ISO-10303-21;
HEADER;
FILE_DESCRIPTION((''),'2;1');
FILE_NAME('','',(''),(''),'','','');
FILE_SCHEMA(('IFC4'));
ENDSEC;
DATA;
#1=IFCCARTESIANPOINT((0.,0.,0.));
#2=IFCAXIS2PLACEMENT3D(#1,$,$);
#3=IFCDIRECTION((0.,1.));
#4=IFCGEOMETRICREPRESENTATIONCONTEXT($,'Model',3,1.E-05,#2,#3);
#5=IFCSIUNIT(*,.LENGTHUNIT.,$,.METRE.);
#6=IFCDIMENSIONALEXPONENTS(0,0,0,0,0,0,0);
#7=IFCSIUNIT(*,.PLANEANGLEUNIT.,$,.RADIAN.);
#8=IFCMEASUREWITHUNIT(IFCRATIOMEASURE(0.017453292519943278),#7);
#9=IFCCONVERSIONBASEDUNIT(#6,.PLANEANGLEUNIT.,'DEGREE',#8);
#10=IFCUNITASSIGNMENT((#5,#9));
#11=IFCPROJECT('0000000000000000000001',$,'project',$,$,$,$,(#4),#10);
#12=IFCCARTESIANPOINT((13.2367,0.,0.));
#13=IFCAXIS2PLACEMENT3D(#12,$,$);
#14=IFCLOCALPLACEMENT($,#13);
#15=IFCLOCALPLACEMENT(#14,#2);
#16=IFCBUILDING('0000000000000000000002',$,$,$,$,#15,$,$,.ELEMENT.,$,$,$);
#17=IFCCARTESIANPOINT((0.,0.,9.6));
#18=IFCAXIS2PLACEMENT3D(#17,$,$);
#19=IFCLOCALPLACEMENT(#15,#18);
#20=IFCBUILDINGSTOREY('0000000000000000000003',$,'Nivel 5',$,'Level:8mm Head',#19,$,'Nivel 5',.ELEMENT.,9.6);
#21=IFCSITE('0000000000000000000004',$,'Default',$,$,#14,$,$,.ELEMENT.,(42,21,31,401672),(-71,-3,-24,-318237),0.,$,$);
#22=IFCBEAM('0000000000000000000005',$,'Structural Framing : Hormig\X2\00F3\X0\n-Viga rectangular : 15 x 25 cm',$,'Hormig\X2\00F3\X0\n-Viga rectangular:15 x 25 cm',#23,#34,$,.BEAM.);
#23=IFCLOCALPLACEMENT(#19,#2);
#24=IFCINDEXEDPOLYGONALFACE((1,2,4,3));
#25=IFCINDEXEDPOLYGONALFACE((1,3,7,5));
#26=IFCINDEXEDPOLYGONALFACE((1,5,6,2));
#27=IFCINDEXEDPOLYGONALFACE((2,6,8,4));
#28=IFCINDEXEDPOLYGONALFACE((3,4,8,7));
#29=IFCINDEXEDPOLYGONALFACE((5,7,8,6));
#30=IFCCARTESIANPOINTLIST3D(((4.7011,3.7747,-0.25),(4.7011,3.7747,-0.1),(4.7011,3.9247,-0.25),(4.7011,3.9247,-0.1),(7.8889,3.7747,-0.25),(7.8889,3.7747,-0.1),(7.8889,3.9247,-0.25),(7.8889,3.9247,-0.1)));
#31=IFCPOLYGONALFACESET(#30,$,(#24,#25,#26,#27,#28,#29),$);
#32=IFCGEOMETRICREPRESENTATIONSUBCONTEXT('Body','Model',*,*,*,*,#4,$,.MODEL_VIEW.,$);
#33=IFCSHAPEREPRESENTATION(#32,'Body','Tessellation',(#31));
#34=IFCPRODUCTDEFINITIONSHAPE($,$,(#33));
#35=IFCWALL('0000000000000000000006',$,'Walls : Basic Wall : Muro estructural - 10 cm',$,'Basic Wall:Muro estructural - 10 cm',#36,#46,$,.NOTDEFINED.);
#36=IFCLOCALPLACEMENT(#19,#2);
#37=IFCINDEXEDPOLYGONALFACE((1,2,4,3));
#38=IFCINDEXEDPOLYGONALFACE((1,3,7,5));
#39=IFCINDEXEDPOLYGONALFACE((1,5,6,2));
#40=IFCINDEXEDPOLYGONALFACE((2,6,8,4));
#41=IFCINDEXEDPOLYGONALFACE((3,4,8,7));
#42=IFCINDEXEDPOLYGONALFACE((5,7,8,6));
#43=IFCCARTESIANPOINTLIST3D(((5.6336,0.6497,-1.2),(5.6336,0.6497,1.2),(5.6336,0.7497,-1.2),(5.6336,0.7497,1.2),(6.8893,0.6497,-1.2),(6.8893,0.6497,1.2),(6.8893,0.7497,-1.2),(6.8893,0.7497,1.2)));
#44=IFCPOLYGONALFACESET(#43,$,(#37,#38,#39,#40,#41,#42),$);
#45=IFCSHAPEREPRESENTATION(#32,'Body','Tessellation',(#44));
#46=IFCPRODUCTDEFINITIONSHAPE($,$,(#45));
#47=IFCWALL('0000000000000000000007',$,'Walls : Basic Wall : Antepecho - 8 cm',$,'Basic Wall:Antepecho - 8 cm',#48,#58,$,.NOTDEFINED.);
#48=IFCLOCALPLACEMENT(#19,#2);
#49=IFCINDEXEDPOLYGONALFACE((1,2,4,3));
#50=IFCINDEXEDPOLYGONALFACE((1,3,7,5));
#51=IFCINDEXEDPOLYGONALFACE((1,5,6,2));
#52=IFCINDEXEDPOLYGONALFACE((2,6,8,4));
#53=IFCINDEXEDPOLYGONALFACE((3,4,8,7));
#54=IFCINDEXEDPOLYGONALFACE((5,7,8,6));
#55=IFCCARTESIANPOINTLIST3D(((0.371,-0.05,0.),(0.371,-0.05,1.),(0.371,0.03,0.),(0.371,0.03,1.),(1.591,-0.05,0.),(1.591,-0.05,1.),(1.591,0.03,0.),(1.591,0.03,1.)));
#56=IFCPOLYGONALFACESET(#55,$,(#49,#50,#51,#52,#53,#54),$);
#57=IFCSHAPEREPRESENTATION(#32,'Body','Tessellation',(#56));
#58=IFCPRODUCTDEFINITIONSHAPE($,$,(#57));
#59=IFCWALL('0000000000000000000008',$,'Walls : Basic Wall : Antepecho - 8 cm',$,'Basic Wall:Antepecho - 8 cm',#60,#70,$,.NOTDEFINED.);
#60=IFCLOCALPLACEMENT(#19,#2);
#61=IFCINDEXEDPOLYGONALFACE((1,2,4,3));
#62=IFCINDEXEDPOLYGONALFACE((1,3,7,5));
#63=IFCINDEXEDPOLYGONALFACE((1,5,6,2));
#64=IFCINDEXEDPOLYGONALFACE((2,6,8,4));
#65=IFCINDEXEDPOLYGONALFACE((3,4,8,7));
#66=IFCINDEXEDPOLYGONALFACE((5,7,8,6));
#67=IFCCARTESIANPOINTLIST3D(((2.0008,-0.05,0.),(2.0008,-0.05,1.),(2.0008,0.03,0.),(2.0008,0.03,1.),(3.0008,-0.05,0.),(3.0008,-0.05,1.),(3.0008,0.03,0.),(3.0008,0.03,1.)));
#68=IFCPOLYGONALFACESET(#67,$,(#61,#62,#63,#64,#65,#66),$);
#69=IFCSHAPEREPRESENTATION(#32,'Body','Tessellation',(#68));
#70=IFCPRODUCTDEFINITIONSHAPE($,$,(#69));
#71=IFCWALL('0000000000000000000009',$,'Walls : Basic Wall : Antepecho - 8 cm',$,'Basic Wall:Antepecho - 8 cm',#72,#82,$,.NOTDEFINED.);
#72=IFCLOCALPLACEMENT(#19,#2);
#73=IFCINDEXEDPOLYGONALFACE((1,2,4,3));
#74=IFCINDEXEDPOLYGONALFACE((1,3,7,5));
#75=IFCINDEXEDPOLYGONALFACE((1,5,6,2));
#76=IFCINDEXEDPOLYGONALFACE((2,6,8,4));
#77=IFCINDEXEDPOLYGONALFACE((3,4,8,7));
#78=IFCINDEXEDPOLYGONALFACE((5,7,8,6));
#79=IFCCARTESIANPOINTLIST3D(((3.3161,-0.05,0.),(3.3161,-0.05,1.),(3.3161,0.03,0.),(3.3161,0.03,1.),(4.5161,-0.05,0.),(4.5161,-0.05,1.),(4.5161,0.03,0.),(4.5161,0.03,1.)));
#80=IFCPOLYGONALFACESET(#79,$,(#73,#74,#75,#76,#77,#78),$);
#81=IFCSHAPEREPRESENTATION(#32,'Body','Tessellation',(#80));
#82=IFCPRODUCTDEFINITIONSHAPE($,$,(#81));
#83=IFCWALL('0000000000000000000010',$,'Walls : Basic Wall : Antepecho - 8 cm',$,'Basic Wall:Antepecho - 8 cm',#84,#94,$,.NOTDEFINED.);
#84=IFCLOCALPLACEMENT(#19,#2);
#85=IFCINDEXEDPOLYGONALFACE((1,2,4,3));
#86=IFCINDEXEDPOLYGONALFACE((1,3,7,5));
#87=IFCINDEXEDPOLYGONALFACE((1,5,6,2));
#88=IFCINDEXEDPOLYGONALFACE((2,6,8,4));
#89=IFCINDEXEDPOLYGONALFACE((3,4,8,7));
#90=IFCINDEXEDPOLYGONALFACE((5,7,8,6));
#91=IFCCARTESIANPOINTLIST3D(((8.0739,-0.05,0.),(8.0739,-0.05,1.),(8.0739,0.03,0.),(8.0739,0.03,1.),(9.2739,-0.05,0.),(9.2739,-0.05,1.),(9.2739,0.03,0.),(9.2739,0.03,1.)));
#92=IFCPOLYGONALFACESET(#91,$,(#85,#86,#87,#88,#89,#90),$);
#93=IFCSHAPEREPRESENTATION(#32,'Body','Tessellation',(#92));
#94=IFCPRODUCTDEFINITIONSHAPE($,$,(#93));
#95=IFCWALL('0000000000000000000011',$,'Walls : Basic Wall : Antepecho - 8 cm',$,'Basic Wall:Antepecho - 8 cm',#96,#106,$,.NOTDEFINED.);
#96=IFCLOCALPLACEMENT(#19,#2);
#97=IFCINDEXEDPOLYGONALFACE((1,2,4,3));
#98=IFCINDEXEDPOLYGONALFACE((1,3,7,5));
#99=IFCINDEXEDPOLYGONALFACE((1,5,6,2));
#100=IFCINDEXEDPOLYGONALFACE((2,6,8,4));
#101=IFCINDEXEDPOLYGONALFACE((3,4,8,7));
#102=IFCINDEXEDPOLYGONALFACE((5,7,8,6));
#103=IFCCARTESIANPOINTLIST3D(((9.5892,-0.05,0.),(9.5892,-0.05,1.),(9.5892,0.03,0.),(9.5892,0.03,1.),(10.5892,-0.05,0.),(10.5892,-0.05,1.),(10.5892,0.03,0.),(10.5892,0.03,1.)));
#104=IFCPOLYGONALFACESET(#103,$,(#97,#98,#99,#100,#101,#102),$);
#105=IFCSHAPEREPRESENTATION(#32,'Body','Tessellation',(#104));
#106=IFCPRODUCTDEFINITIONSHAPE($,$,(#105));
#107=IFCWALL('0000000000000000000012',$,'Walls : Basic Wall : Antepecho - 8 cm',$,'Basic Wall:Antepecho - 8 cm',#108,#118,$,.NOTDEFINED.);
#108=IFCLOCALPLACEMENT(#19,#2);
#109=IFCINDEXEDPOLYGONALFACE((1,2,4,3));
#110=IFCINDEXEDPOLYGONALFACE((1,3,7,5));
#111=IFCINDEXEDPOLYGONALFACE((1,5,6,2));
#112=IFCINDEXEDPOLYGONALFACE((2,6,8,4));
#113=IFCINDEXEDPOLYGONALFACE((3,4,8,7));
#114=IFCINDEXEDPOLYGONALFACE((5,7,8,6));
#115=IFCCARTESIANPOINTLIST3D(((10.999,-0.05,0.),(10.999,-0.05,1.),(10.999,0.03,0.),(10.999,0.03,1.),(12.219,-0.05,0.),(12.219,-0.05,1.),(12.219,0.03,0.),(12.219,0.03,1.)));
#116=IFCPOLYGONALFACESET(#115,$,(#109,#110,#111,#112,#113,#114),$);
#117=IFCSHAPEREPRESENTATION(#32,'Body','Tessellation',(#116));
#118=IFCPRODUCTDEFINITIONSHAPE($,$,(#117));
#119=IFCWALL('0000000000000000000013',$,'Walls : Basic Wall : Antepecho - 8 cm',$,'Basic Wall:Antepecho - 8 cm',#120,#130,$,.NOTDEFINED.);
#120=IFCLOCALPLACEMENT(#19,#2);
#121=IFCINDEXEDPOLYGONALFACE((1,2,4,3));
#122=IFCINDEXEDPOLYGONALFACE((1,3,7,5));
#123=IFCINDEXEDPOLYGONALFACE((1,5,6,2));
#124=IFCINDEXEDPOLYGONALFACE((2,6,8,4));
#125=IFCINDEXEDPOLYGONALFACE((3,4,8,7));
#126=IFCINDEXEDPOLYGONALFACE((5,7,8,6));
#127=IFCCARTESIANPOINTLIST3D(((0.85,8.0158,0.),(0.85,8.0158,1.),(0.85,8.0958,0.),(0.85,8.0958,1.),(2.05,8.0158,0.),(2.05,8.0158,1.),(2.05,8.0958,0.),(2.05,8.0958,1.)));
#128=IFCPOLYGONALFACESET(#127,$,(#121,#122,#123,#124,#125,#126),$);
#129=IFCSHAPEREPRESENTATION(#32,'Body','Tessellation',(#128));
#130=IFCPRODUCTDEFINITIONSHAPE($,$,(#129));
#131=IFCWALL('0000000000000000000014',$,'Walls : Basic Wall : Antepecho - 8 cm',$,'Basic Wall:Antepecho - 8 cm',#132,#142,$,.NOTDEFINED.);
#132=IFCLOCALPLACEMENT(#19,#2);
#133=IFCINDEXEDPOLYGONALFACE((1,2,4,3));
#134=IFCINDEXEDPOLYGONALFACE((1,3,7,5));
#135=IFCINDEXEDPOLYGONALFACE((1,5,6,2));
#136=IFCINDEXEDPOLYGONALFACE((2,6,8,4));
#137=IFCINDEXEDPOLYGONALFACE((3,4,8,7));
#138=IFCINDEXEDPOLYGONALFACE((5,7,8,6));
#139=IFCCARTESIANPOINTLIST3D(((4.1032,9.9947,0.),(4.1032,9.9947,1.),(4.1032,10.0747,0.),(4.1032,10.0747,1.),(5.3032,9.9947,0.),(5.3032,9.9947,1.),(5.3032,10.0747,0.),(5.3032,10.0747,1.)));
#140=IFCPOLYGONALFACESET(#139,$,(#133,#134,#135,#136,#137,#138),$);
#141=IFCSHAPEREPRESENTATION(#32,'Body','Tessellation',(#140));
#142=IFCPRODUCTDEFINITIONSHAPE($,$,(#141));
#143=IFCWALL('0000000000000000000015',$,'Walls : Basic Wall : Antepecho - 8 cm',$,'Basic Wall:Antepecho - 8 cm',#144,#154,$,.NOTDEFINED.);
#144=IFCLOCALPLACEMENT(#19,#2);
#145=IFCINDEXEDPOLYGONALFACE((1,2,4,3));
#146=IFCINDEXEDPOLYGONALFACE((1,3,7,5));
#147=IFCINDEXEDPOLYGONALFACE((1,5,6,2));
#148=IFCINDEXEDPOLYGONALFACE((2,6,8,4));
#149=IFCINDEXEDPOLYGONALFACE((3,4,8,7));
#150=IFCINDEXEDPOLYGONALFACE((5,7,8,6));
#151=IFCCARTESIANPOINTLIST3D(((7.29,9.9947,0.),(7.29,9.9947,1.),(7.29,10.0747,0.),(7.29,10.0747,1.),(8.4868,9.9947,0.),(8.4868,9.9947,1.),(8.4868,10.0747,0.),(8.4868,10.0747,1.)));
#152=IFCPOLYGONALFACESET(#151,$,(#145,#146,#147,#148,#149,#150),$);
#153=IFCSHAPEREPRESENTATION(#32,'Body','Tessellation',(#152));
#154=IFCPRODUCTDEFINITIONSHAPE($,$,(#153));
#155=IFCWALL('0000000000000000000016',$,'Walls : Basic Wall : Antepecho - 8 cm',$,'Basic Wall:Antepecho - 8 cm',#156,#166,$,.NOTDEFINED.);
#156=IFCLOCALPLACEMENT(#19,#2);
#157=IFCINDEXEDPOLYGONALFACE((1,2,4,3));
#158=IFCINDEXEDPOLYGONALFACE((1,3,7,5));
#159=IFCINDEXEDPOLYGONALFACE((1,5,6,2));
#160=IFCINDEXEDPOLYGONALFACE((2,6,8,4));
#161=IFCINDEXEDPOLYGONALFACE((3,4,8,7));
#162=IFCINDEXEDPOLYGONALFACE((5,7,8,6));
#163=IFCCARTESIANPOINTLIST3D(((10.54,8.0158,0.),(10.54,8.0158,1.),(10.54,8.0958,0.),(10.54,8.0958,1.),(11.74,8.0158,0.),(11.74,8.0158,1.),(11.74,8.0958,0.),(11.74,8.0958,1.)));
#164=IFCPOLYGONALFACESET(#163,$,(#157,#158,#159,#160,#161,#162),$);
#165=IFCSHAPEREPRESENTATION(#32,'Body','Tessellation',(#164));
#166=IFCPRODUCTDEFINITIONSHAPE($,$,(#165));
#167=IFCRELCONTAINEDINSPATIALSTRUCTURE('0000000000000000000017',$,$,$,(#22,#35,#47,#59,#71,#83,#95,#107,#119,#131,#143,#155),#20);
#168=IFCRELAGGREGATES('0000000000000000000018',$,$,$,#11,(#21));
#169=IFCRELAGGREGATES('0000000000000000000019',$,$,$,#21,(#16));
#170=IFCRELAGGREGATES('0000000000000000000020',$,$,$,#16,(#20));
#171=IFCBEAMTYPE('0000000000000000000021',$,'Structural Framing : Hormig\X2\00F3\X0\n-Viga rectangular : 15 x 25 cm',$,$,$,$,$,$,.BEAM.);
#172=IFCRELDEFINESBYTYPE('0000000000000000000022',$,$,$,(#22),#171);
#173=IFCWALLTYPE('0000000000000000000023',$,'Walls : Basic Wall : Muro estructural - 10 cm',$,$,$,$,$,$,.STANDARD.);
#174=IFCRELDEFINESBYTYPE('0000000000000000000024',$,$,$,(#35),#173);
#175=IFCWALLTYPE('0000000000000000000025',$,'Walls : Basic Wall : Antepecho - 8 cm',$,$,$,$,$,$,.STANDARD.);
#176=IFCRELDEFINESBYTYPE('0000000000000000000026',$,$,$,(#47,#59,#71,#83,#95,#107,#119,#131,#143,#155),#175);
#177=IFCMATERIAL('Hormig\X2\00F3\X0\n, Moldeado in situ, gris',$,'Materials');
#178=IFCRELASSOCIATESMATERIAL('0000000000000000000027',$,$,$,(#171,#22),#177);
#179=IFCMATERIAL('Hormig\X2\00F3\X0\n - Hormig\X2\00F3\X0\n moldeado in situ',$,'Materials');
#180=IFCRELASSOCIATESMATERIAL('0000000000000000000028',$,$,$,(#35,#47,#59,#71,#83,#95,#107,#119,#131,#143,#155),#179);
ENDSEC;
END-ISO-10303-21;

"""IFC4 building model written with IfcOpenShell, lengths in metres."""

from ifc_helpers import new_model, entity, si_unit, converted_unit, direction, frame, origin, place, context, subcontext, project, spatial, indexed_curve, outline, extrude, source, transform, mapped, material, type_object, type_shapes, element, save


model = new_model("IFC4")

# Units and contexts
model_context = context("Model", 3, precision=1e-05, world=origin(), true_north=direction((0.0, 1.0)))
body_context = subcontext(model_context, "Body", "Model", "MODEL_VIEW")
ifc_project = project(units=[si_unit("LENGTHUNIT", "METRE"), converted_unit("PLANEANGLEUNIT", "DEGREE", entity("IfcRatioMeasure", 0.017453292519943278), si_unit("PLANEANGLEUNIT", "RADIAN"), dimensions=[0, 0, 0, 0, 0, 0, 0])], contexts=[model_context])

# Site, building, storey
site_placement = place(None, frame((13.2367, 0.0, 0.0)))
site = spatial("IfcSite", under=ifc_project, at=site_placement, Name="Default", CompositionType="ELEMENT", RefLatitude=(42, 21, 31, 401672), RefLongitude=(-71, -3, -24, -318237), RefElevation=0.0)
building_placement = place(site_placement, origin())
building = spatial("IfcBuilding", under=site, at=building_placement, CompositionType="ELEMENT")
storey_placement = place(building_placement, frame((0.0, 0.0, 9.6)))
storey = spatial("IfcBuildingStorey", under=building, at=storey_placement, Name="Nivel 5", ObjectType="Level:8mm Head", LongName="Nivel 5", CompositionType="ELEMENT", Elevation=9.6)

# Beam
ifc_material_1 = material(Name="Hormigón, Moldeado in situ, gris", Category="Materials")
beam_type_1 = type_object("IfcBeamType", Name="Structural Framing : Hormigón-Viga rectangular : 15 x 25 cm", PredefinedType="BEAM", material=ifc_material_1)
shared_shape_1 = source(origin(), body_context, "Body", "SweptSolid", [
    extrude(outline(indexed_curve([(-0.075, -0.075), (0.075, -0.075), (0.075, 0.075), (-0.075, 0.075), (-0.075, -0.075)], self_intersect=False)), frame((4.7011, 3.8497, 9.425), z_axis=(1.0, 0.0, 0.0), x_axis=(0.0, 0.0, -1.0)), (0.0, 0.0, 1.0), 3.1878),
])
type_shapes(beam_type_1, [shared_shape_1])
beam_1_placement = place(storey_placement, frame((0.0, 0.0, -9.6)))
element("IfcBeam", 1, at=beam_1_placement, inside=storey, type_object=beam_type_1, material=ifc_material_1, Name="Structural Framing : Hormigón-Viga rectangular : 15 x 25 cm", ObjectType="Hormigón-Viga rectangular:15 x 25 cm", PredefinedType="BEAM", context=body_context, shape_type="MappedRepresentation", body=[
    mapped(shared_shape_1, transform((0.0, 0.0, 0.0), scale=1.0)),
])

# Shared definitions
ifc_material_2 = material(Name="Hormigón - Hormigón moldeado in situ", Category="Materials")

# Walls
wall_type_1 = type_object("IfcWallType", Name="Walls : Basic Wall : Muro estructural - 10 cm", PredefinedType="STANDARD")
wall_1_placement = place(storey_placement, frame((5.6336, 0.6997, -1.2)))
element("IfcWall", 2, at=wall_1_placement, inside=storey, type_object=wall_type_1, material=ifc_material_2, Name="Walls : Basic Wall : Muro estructural - 10 cm", ObjectType="Basic Wall:Muro estructural - 10 cm", PredefinedType="NOTDEFINED", context=body_context, shape_type="SweptSolid", body=[
    extrude(outline(indexed_curve([(1.2557, 0.05), (0.0, 0.05), (0.0, -0.05), (1.2557, -0.05), (1.2557, 0.05)], self_intersect=False)), origin(), (0.0, 0.0, 1.0), 2.4),
])
wall_type_2 = type_object("IfcWallType", Name="Walls : Basic Wall : Antepecho - 8 cm", PredefinedType="STANDARD")
wall_2_placement = place(storey_placement, frame((0.371, -0.01, 0.0)))
element("IfcWall", 3, at=wall_2_placement, inside=storey, type_object=wall_type_2, material=ifc_material_2, Name="Walls : Basic Wall : Antepecho - 8 cm", ObjectType="Basic Wall:Antepecho - 8 cm", PredefinedType="NOTDEFINED", context=body_context, shape_type="SweptSolid", body=[
    extrude(outline(indexed_curve([(1.22, 0.04), (0.0, 0.04), (0.0, -0.04), (1.22, -0.04), (1.22, 0.04)], self_intersect=False)), origin(), (0.0, 0.0, 1.0), 1.0),
])
wall_3_placement = place(storey_placement, frame((2.0008, -0.01, 0.0)))
element("IfcWall", 4, at=wall_3_placement, inside=storey, type_object=wall_type_2, material=ifc_material_2, Name="Walls : Basic Wall : Antepecho - 8 cm", ObjectType="Basic Wall:Antepecho - 8 cm", PredefinedType="NOTDEFINED", context=body_context, shape_type="SweptSolid", body=[
    extrude(outline(indexed_curve([(1.0, 0.04), (0.0, 0.04), (0.0, -0.04), (1.0, -0.04), (1.0, 0.04)], self_intersect=False)), origin(), (0.0, 0.0, 1.0), 1.0),
])
wall_4_placement = place(storey_placement, frame((3.3161, -0.01, 0.0)))
element("IfcWall", 5, at=wall_4_placement, inside=storey, type_object=wall_type_2, material=ifc_material_2, Name="Walls : Basic Wall : Antepecho - 8 cm", ObjectType="Basic Wall:Antepecho - 8 cm", PredefinedType="NOTDEFINED", context=body_context, shape_type="SweptSolid", body=[
    extrude(outline(indexed_curve([(1.2, 0.04), (0.0, 0.04), (0.0, -0.04), (1.2, -0.04), (1.2, 0.04)], self_intersect=False)), origin(), (0.0, 0.0, 1.0), 1.0),
])
wall_5_placement = place(storey_placement, frame((8.0739, -0.01, 0.0)))
element("IfcWall", 6, at=wall_5_placement, inside=storey, type_object=wall_type_2, material=ifc_material_2, Name="Walls : Basic Wall : Antepecho - 8 cm", ObjectType="Basic Wall:Antepecho - 8 cm", PredefinedType="NOTDEFINED", context=body_context, shape_type="SweptSolid", body=[
    extrude(outline(indexed_curve([(1.2, 0.04), (0.0, 0.04), (0.0, -0.04), (1.2, -0.04), (1.2, 0.04)], self_intersect=False)), origin(), (0.0, 0.0, 1.0), 1.0),
])
wall_6_placement = place(storey_placement, frame((9.5892, -0.01, 0.0)))
element("IfcWall", 7, at=wall_6_placement, inside=storey, type_object=wall_type_2, material=ifc_material_2, Name="Walls : Basic Wall : Antepecho - 8 cm", ObjectType="Basic Wall:Antepecho - 8 cm", PredefinedType="NOTDEFINED", context=body_context, shape_type="SweptSolid", body=[
    extrude(outline(indexed_curve([(1.0, 0.04), (0.0, 0.04), (0.0, -0.04), (1.0, -0.04), (1.0, 0.04)], self_intersect=False)), origin(), (0.0, 0.0, 1.0), 1.0),
])
wall_7_placement = place(storey_placement, frame((10.999, -0.01, 0.0)))
element("IfcWall", 8, at=wall_7_placement, inside=storey, type_object=wall_type_2, material=ifc_material_2, Name="Walls : Basic Wall : Antepecho - 8 cm", ObjectType="Basic Wall:Antepecho - 8 cm", PredefinedType="NOTDEFINED", context=body_context, shape_type="SweptSolid", body=[
    extrude(outline(indexed_curve([(1.22, 0.04), (0.0, 0.04), (0.0, -0.04), (1.22, -0.04), (1.22, 0.04)], self_intersect=False)), origin(), (0.0, 0.0, 1.0), 1.0),
])
wall_8_placement = place(storey_placement, frame((2.05, 8.0558, 0.0), z_axis=(0.0, 0.0, 1.0), x_axis=(-1.0, 0.0, 0.0)))
element("IfcWall", 9, at=wall_8_placement, inside=storey, type_object=wall_type_2, material=ifc_material_2, Name="Walls : Basic Wall : Antepecho - 8 cm", ObjectType="Basic Wall:Antepecho - 8 cm", PredefinedType="NOTDEFINED", context=body_context, shape_type="SweptSolid", body=[
    extrude(outline(indexed_curve([(1.2, 0.04), (0.0, 0.04), (0.0, -0.04), (1.2, -0.04), (1.2, 0.04)], self_intersect=False)), origin(), (0.0, 0.0, 1.0), 1.0),
])
wall_9_placement = place(storey_placement, frame((5.3032, 10.0347, 0.0), z_axis=(0.0, 0.0, 1.0), x_axis=(-1.0, 0.0, 0.0)))
element("IfcWall", 10, at=wall_9_placement, inside=storey, type_object=wall_type_2, material=ifc_material_2, Name="Walls : Basic Wall : Antepecho - 8 cm", ObjectType="Basic Wall:Antepecho - 8 cm", PredefinedType="NOTDEFINED", context=body_context, shape_type="SweptSolid", body=[
    extrude(outline(indexed_curve([(1.2, 0.04), (0.0, 0.04), (0.0, -0.04), (1.2, -0.04), (1.2, 0.04)], self_intersect=False)), origin(), (0.0, 0.0, 1.0), 1.0),
])
wall_10_placement = place(storey_placement, frame((8.4868, 10.0347, 0.0), z_axis=(0.0, 0.0, 1.0), x_axis=(-1.0, 0.0, 0.0)))
element("IfcWall", 11, at=wall_10_placement, inside=storey, type_object=wall_type_2, material=ifc_material_2, Name="Walls : Basic Wall : Antepecho - 8 cm", ObjectType="Basic Wall:Antepecho - 8 cm", PredefinedType="NOTDEFINED", context=body_context, shape_type="SweptSolid", body=[
    extrude(outline(indexed_curve([(1.1968, 0.04), (0.0, 0.04), (0.0, -0.04), (1.1968, -0.04), (1.1968, 0.04)], self_intersect=False)), origin(), (0.0, 0.0, 1.0), 1.0),
])
wall_11_placement = place(storey_placement, frame((11.74, 8.0558, 0.0), z_axis=(0.0, 0.0, 1.0), x_axis=(-1.0, 0.0, 0.0)))
element("IfcWall", 12, at=wall_11_placement, inside=storey, type_object=wall_type_2, material=ifc_material_2, Name="Walls : Basic Wall : Antepecho - 8 cm", ObjectType="Basic Wall:Antepecho - 8 cm", PredefinedType="NOTDEFINED", context=body_context, shape_type="SweptSolid", body=[
    extrude(outline(indexed_curve([(1.2, 0.04), (0.0, 0.04), (0.0, -0.04), (1.2, -0.04), (1.2, 0.04)], self_intersect=False)), origin(), (0.0, 0.0, 1.0), 1.0),
])

save(model, "model.ifc")
